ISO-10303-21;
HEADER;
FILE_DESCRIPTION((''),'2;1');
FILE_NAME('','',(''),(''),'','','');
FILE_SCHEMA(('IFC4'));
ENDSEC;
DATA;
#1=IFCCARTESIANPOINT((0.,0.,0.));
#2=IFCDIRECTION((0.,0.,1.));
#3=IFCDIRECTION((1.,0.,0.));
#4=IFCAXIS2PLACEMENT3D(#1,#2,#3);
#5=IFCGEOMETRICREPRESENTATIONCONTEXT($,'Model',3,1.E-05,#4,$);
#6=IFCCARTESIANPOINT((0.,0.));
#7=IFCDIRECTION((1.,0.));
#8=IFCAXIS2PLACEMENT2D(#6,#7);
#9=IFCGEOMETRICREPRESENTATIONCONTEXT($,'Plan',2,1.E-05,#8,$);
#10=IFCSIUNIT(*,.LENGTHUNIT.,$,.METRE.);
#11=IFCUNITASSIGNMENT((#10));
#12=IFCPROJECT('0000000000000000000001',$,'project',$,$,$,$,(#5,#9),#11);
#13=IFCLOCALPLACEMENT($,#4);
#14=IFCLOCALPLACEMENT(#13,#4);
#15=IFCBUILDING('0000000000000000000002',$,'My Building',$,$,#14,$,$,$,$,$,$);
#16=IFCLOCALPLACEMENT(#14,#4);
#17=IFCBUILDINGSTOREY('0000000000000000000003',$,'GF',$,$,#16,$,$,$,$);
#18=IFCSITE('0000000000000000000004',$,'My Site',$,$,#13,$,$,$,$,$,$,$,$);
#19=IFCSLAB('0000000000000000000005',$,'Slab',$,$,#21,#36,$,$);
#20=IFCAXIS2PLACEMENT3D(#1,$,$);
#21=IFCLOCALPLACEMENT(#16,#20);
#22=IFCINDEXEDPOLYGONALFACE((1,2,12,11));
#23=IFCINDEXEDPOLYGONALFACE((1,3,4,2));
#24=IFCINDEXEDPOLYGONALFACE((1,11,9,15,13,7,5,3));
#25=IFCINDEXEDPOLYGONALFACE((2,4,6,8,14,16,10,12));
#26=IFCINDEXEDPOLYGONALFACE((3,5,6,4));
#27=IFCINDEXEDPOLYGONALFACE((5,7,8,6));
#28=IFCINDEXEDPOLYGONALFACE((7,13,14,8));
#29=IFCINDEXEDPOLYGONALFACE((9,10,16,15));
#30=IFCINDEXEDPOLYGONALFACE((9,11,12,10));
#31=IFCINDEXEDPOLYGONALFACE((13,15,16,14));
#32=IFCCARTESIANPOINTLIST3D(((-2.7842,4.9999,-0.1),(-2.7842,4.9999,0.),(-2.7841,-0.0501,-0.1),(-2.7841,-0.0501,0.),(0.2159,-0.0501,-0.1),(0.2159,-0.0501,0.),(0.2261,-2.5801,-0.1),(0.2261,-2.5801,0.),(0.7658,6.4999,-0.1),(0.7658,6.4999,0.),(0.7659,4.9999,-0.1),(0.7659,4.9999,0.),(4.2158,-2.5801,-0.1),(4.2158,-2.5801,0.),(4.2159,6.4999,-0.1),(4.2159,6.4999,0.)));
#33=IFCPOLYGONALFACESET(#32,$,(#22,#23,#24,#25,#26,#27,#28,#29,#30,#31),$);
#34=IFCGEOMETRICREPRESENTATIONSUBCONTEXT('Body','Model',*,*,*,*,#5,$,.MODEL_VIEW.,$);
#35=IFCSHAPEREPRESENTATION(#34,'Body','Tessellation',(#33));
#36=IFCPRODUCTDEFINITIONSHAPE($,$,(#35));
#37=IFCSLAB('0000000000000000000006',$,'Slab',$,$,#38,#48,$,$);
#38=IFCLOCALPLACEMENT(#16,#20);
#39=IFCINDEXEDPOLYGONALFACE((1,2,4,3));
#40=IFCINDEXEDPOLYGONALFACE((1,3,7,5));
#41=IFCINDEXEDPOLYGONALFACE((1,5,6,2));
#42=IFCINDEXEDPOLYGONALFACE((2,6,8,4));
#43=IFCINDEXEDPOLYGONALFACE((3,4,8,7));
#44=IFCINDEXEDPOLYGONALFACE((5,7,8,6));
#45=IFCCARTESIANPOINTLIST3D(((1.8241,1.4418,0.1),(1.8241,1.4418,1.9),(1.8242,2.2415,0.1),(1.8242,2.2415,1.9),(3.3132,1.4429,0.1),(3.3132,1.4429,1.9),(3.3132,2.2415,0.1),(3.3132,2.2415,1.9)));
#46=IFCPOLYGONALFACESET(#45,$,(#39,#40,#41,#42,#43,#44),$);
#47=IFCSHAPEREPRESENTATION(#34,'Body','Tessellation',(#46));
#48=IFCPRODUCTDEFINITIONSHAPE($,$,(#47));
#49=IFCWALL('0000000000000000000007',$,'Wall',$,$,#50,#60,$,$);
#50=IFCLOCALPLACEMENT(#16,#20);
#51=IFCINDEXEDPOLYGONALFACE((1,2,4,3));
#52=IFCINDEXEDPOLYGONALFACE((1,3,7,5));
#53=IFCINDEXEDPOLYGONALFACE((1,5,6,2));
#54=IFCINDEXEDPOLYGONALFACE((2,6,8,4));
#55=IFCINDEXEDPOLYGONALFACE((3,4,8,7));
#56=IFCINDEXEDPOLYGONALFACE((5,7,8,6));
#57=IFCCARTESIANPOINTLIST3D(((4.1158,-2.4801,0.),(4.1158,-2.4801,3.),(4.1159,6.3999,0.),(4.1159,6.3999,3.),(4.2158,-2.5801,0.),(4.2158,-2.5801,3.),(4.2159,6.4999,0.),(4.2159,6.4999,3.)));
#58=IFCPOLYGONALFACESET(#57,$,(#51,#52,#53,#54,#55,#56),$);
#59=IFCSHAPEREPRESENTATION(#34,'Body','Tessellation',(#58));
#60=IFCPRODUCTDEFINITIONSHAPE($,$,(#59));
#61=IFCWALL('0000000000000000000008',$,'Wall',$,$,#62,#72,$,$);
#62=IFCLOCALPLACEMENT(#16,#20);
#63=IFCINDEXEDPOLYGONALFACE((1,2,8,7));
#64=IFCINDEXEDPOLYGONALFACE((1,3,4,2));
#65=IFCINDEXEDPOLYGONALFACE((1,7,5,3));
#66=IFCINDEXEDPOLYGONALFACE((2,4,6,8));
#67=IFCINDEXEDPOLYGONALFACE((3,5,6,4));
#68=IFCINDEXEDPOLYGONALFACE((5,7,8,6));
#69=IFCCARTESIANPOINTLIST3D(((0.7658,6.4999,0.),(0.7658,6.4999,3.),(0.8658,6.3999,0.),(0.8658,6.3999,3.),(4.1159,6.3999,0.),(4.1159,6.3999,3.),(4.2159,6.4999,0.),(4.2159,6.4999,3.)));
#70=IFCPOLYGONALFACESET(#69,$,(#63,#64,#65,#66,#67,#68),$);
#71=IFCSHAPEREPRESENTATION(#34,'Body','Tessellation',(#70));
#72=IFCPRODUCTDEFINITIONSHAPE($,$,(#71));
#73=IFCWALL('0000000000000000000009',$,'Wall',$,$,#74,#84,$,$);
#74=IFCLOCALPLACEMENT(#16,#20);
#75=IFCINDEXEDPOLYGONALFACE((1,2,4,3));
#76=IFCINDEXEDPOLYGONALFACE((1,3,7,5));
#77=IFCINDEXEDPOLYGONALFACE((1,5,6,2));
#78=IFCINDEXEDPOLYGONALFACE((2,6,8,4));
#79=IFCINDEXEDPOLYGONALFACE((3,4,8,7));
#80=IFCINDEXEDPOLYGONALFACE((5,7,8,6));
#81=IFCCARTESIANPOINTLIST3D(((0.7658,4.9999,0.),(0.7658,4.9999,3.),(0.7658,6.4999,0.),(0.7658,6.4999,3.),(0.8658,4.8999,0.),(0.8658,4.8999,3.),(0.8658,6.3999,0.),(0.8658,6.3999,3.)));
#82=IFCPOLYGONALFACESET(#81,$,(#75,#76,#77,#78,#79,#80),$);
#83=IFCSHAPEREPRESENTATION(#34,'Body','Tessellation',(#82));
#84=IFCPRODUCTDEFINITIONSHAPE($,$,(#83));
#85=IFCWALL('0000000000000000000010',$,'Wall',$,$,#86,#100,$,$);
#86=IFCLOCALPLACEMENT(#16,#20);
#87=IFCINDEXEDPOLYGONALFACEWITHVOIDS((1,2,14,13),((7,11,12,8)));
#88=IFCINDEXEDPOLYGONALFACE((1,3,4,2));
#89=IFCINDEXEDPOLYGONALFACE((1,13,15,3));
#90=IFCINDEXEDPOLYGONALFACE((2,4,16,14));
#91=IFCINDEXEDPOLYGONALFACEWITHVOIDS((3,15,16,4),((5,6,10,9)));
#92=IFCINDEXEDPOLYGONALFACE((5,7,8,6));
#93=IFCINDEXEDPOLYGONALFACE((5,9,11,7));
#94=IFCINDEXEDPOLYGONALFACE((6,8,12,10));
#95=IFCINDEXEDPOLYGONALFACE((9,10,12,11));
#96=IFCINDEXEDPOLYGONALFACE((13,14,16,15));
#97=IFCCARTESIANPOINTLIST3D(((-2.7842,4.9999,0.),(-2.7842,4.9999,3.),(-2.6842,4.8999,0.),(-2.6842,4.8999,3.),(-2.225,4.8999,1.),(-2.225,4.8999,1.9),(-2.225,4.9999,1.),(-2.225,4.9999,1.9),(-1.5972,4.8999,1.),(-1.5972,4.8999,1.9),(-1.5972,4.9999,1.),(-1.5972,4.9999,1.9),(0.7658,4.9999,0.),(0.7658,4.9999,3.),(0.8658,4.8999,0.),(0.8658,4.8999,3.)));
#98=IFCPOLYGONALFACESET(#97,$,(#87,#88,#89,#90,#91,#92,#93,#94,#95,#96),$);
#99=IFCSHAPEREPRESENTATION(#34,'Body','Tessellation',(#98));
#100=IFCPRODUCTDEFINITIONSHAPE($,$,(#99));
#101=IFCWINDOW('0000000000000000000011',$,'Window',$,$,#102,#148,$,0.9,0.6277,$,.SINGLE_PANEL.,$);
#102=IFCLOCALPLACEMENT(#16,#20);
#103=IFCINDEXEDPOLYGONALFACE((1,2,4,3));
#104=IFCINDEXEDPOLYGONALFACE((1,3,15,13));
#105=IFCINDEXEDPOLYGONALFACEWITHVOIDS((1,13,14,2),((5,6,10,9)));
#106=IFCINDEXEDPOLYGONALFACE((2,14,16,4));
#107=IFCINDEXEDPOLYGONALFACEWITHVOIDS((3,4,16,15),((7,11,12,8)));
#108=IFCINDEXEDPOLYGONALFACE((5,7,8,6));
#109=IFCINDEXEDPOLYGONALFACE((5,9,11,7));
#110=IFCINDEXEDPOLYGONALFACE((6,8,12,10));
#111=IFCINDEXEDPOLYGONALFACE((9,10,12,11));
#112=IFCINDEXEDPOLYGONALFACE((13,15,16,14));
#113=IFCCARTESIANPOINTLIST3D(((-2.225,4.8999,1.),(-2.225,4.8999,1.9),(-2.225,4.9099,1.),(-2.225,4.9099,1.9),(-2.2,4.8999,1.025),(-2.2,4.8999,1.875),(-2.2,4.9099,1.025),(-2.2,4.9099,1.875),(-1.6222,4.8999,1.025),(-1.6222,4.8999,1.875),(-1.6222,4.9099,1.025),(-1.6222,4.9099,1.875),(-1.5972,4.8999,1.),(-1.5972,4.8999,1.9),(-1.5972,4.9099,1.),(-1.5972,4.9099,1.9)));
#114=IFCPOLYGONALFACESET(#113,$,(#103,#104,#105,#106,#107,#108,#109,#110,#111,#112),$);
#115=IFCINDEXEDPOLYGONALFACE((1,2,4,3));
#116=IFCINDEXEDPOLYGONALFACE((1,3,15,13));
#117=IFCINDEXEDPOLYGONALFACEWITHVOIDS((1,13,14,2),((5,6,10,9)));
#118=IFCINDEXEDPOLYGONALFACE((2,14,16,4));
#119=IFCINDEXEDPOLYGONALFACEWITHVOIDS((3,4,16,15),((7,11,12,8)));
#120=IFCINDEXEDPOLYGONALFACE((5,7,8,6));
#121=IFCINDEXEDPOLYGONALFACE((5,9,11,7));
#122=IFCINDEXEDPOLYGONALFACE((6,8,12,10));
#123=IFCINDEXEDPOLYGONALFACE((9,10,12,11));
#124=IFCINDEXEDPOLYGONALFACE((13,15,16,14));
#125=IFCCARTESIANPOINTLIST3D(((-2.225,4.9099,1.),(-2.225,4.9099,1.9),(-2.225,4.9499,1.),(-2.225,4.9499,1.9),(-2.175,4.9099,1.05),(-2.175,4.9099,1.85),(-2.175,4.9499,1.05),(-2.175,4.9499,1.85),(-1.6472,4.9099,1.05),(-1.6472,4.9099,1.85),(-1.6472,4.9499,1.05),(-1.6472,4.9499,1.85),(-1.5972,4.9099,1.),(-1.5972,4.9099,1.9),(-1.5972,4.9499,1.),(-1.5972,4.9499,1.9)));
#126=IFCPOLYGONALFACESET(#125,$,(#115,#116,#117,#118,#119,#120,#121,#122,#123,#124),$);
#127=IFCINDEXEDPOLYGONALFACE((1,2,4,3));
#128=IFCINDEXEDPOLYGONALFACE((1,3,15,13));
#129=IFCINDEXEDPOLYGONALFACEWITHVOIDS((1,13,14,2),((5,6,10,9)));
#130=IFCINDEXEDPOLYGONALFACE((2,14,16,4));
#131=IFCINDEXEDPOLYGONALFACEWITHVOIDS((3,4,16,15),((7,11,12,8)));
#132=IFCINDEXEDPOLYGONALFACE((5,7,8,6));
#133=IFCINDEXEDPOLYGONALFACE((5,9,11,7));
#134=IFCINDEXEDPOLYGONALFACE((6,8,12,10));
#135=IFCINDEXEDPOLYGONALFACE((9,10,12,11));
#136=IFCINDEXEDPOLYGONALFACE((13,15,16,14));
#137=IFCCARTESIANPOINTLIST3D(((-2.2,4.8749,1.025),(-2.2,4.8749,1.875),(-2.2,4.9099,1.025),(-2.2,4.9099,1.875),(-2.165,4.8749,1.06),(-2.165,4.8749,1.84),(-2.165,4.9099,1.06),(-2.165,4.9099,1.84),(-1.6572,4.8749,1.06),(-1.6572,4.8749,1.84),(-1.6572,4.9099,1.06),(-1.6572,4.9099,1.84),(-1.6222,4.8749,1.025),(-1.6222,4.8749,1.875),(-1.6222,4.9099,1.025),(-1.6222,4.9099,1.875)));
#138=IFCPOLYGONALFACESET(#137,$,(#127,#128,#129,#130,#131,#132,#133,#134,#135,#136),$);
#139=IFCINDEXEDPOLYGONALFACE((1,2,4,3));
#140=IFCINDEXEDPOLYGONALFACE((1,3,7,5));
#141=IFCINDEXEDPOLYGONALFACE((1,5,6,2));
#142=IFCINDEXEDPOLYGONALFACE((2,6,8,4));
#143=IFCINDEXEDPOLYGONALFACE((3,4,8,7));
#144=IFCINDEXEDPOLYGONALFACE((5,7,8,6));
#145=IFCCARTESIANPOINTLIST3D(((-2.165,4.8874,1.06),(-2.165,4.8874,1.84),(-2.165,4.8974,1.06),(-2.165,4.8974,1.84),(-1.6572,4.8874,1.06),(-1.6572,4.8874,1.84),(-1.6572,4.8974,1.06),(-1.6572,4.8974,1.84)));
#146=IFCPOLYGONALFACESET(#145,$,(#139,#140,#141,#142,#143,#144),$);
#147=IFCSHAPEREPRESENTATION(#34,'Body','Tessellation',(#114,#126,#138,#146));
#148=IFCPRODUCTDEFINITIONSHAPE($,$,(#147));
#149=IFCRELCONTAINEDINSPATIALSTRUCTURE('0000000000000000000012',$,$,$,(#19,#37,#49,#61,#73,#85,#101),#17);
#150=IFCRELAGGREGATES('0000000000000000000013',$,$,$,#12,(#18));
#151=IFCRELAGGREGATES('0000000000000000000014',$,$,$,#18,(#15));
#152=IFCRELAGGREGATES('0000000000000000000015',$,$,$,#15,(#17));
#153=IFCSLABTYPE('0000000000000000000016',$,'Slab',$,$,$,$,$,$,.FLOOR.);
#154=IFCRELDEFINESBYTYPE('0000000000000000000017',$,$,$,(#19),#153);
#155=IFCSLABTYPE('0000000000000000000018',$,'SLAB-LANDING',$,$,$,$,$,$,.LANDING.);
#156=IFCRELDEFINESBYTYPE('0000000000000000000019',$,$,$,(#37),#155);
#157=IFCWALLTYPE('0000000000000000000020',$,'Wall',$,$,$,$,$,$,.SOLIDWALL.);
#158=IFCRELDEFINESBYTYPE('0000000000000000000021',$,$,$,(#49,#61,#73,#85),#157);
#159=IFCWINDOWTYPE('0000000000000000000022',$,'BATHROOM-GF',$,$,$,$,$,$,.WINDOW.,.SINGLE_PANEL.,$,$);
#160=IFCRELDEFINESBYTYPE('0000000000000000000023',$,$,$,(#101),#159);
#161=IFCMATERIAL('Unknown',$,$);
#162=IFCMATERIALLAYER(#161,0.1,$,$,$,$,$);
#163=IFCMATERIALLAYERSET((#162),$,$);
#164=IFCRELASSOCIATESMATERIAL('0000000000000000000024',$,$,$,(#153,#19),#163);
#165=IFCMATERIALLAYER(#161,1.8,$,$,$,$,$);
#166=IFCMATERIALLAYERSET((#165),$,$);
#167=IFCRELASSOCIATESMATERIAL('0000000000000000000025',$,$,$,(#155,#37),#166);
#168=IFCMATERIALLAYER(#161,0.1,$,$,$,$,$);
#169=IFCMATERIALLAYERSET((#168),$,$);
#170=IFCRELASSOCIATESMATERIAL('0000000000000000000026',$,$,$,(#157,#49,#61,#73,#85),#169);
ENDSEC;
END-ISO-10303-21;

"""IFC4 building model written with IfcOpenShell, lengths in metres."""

from ifc_helpers import new_model, entity, si_unit, frame, origin_with_axes, origin_2d_with_axis, place, context, subcontext, project, spatial, line, indexed_curve, outline, extrude, shape, source, transform, mapped, material, layer, layer_set, layer_usage, type_object, type_shapes, element, fill, save


model = new_model("IFC4")

# Units and contexts
model_context = context("Model", 3, precision=1e-05, world=origin_with_axes())
plan_context = context("Plan", 2, precision=1e-05, world=origin_2d_with_axis())
body_context_1 = subcontext(model_context, "Body", "Model", "MODEL_VIEW")
body_context_2 = subcontext(plan_context, "Body", "Plan", "PLAN_VIEW")
ifc_project = project(units=[si_unit("LENGTHUNIT", "METRE")], contexts=[model_context, plan_context])

# Site, building, storey
site_placement = place(None, origin_with_axes())
site = spatial("IfcSite", under=ifc_project, at=site_placement, Name="My Site")
building_placement = place(site_placement, origin_with_axes())
building = spatial("IfcBuilding", under=site, at=building_placement, Name="My Building")
storey_placement = place(building_placement, origin_with_axes())
storey = spatial("IfcBuildingStorey", under=building, at=storey_placement, Name="GF")

# Slabs
ifc_material_1 = material(Name="Unknown")
ifc_layer_1 = layer(ifc_material_1, 0.1)
ifc_layer_set_1 = layer_set([ifc_layer_1])
ifc_layer_usage_1 = layer_usage(ifc_layer_set_1, "AXIS3", "POSITIVE", -0.1)
slab_type_1 = type_object("IfcSlabType", Name="Slab", PredefinedType="FLOOR", material=ifc_layer_set_1)
slab_1_placement = place(storey_placement, frame((0.2261, -2.5801, 0.0), z_axis=(0.0, 0.0, 1.0), x_axis=(1.0, 0.0, 0.0)))
element("IfcSlab", 1, at=slab_1_placement, inside=storey, type_object=slab_type_1, material=ifc_layer_usage_1, Name="Slab", context=body_context_1, shape_type="SweptSolid", body=[
    extrude(outline(indexed_curve([(0.0, 0.0), (3.9897, 0.0), (3.9897, 9.08), (0.5397, 9.08), (0.5397, 7.58), (-3.0103, 7.58), (-3.0103, 2.53), (-0.0103, 2.53), (0.0, 0.0)])), frame((0.0, 0.0, -0.1), z_axis=(0.0, 0.0, 1.0), x_axis=(1.0, 0.0, 0.0)), (0.0, 0.0, 1.0), 0.1),
])
ifc_layer_2 = layer(ifc_material_1, 1.8)
ifc_layer_set_2 = layer_set([ifc_layer_2])
slab_type_2 = type_object("IfcSlabType", Name="SLAB-LANDING", PredefinedType="LANDING", material=ifc_layer_set_2)
ifc_layer_usage_2 = layer_usage(ifc_layer_set_2, "AXIS3", "POSITIVE", -1.8)
slab_2_placement = place(storey_placement, frame((1.8241, 1.4418, 1.9), z_axis=(0.0, 0.0, 1.0), x_axis=(1.0, 0.0, 0.0)))
element("IfcSlab", 2, at=slab_2_placement, inside=storey, type_object=slab_type_2, material=ifc_layer_usage_2, Name="Slab", context=body_context_1, shape_type="SweptSolid", body=[
    extrude(outline(indexed_curve([(0.0, 0.0), (1.489, 0.0011), (1.489, 0.7997), (0.0, 0.7997), (0.0, 0.0)])), frame((0.0, 0.0, -1.8), z_axis=(0.0, 0.0, 1.0), x_axis=(1.0, 0.0, 0.0)), (0.0, 0.0, 1.0), 1.8),
])

# Shared definitions
ifc_layer_3 = layer(ifc_material_1, 0.1)
ifc_layer_set_3 = layer_set([ifc_layer_3])
wall_type = type_object("IfcWallType", Name="Wall", PredefinedType="SOLIDWALL", material=ifc_layer_set_3)

# Walls
ifc_layer_usage_3 = layer_usage(ifc_layer_set_3, "AXIS2", "POSITIVE", 0.0)
wall_1_placement = place(storey_placement, frame((4.2158, -2.5801, 0.0), z_axis=(0.0, 0.0, 1.0), x_axis=(0.0, 1.0, 0.0)))
element("IfcWall", 3, at=wall_1_placement, inside=storey, type_object=wall_type, material=ifc_layer_usage_3, Name="Wall", context=body_context_1, shape_type="SweptSolid", body=[
    extrude(outline(indexed_curve([(0.0, 0.0), (0.1, 0.1), (8.98, 0.1), (9.08, 0.0)], segments=[line(1, 2, 3, 4, 1)])), origin_with_axes(), (0.0, 0.0, 1.0), 3.0),
])
ifc_layer_usage_4 = layer_usage(ifc_layer_set_3, "AXIS2", "POSITIVE", 0.0)
wall_2_placement = place(storey_placement, frame((4.2159, 6.4999, 0.0), z_axis=(0.0, 0.0, 1.0), x_axis=(-1.0, 0.0, 0.0)))
element("IfcWall", 4, at=wall_2_placement, inside=storey, type_object=wall_type, material=ifc_layer_usage_4, Name="Wall", context=body_context_1, shape_type="SweptSolid", body=[
    extrude(outline(indexed_curve([(0.0, 0.0), (0.1, 0.1), (3.35, 0.1), (3.45, 0.0)], segments=[line(1, 2, 3, 4, 1)])), origin_with_axes(), (0.0, 0.0, 1.0), 3.0),
])
ifc_layer_usage_5 = layer_usage(ifc_layer_set_3, "AXIS2", "POSITIVE", 0.0)
wall_3_placement = place(storey_placement, frame((0.7658, 6.4999, 0.0), z_axis=(0.0, 0.0, 1.0), x_axis=(0.0, -1.0, 0.0)))
element("IfcWall", 5, at=wall_3_placement, inside=storey, type_object=wall_type, material=ifc_layer_usage_5, Name="Wall", context=body_context_1, shape_type="SweptSolid", body=[
    extrude(outline(indexed_curve([(0.0, 0.0), (0.1, 0.1), (1.6, 0.1), (1.5, 0.0)], segments=[line(1, 2, 3, 4, 1)])), origin_with_axes(), (0.0, 0.0, 1.0), 3.0),
])

# Wall, opening, window
ifc_layer_usage_6 = layer_usage(ifc_layer_set_3, "AXIS2", "POSITIVE", 0.0)
wall_4_placement = place(storey_placement, frame((0.7658, 4.9999, 0.0), z_axis=(0.0, 0.0, 1.0), x_axis=(-1.0, 0.0, 0.0)))
wall_4 = element("IfcWall", 6, at=wall_4_placement, inside=storey, type_object=wall_type, material=ifc_layer_usage_6, Name="Wall", context=body_context_1, shape_type="SweptSolid", body=[
    extrude(outline(indexed_curve([(0.0, 0.0), (-0.1, 0.1), (3.45, 0.1), (3.55, 0.0)], segments=[line(1, 2, 3, 4, 1)])), origin_with_axes(), (0.0, 0.0, 1.0), 3.0),
])
shared_shape_1 = source(origin_with_axes(), body_context_1, "Body", "SweptSolid", [
    extrude(outline(indexed_curve([(0.0, 0.0), (0.6277, 0.0), (0.6277, 0.9), (0.0, 0.9)], segments=[line(1, 2, 3, 4, 1)])), frame((0.0, -0.6, 0.0), z_axis=(0.0, -1.0, 0.0), x_axis=(1.0, 0.0, 0.0)), (0.0, 0.0, -1.0), 1.2),
])
opening_1_placement = place(wall_4_placement, frame((2.3631, 0.0, 1.0), z_axis=(0.0, 0.0, 1.0), x_axis=(1.0, 0.0, 0.0)))
opening_1 = element("IfcOpeningElement", 7, at=opening_1_placement, cuts=wall_4, PredefinedType="OPENING", context=body_context_1, shape_type="MappedRepresentation", body=[
    mapped(shared_shape_1, transform((0.0, 0.0, 0.0), x_axis=(1.0, 0.0, 0.0), y_axis=(0.0, 1.0, 0.0), z_axis=(0.0, 0.0, 1.0), scale=1.0)),
])
window_type_1 = type_object("IfcWindowType", Name="BATHROOM-GF", PartitioningType="SINGLE_PANEL", PredefinedType="WINDOW")
shared_shape_2 = source(origin_with_axes(), body_context_1, "Body", "SweptSolid", [
    extrude(outline(indexed_curve([(0.0, 0.0), (0.6277, 0.0), (0.6277, 0.9), (0.0, 0.9)], segments=[line(1, 2, 3, 4, 1)]), holes=[indexed_curve([(0.025, 0.025), (0.6027, 0.025), (0.6027, 0.875), (0.025, 0.875)], segments=[line(1, 2, 3, 4, 1)])]), frame((0.0, 0.09, 0.0), z_axis=(0.0, -1.0, 0.0), x_axis=(1.0, 0.0, 0.0)), (0.0, 0.0, -1.0), 0.01),
    extrude(outline(indexed_curve([(0.0, 0.0), (0.6277, 0.0), (0.6277, 0.9), (0.0, 0.9)], segments=[line(1, 2, 3, 4, 1)]), holes=[indexed_curve([(0.05, 0.05), (0.5777, 0.05), (0.5777, 0.85), (0.05, 0.85)], segments=[line(1, 2, 3, 4, 1)])]), frame((0.0, 0.05, 0.0), z_axis=(0.0, -1.0, 0.0), x_axis=(1.0, 0.0, 0.0)), (0.0, 0.0, -1.0), 0.04),
    extrude(outline(indexed_curve([(0.0, 0.0), (0.5777, 0.0), (0.5777, 0.85), (0.0, 0.85)], segments=[line(1, 2, 3, 4, 1)]), holes=[indexed_curve([(0.035, 0.035), (0.5427, 0.035), (0.5427, 0.815), (0.035, 0.815)], segments=[line(1, 2, 3, 4, 1)])]), frame((0.025, 0.09, 0.025), z_axis=(0.0, -1.0, 0.0), x_axis=(1.0, 0.0, 0.0)), (0.0, 0.0, -1.0), 0.035),
    extrude(outline(indexed_curve([(0.035, 0.035), (0.5427, 0.035), (0.5427, 0.815), (0.035, 0.815)], segments=[line(1, 2, 3, 4, 1)])), frame((0.025, 0.1025, 0.025), z_axis=(0.0, -1.0, 0.0), x_axis=(1.0, 0.0, 0.0)), (0.0, 0.0, -1.0), 0.01),
])
shared_shape_3 = source(origin_with_axes(), body_context_2, "Body", "Curve2D", [
    entity("IfcIndexedPolyCurve", entity("IfcCartesianPointList2D", [[0.05, 0.05], [0.5777, 0.05]])),
    entity("IfcIndexedPolyCurve", entity("IfcCartesianPointList2D", [[0.0, 0.1], [0.025, 0.1], [0.025, 0.09], [0.05, 0.09], [0.05, 0.05], [0.0, 0.05]]), [entity("IfcLineIndex", [1, 2, 3, 4, 5, 6, 1])]),
    entity("IfcIndexedPolyCurve", entity("IfcCartesianPointList2D", [[0.6277, 0.1], [0.6027, 0.1], [0.6027, 0.09], [0.5777, 0.09], [0.5777, 0.05], [0.6277, 0.05]]), [entity("IfcLineIndex", [1, 2, 3, 4, 5, 6, 1])]),
    entity("IfcIndexedPolyCurve", entity("IfcCartesianPointList2D", [[0.025, 0.09], [0.06, 0.09], [0.06, 0.125], [0.025, 0.125]]), [entity("IfcLineIndex", [1, 2, 3, 4, 1])]),
    entity("IfcIndexedPolyCurve", entity("IfcCartesianPointList2D", [[0.6027, 0.09], [0.5677, 0.09], [0.5677, 0.125], [0.6027, 0.125]]), [entity("IfcLineIndex", [1, 2, 3, 4, 1])]),
    entity("IfcIndexedPolyCurve", entity("IfcCartesianPointList2D", [[0.06, 0.09], [0.5677, 0.09]])),
    entity("IfcIndexedPolyCurve", entity("IfcCartesianPointList2D", [[0.06, 0.125], [0.5677, 0.125]])),
    entity("IfcIndexedPolyCurve", entity("IfcCartesianPointList2D", [[0.06, 0.1075], [0.5677, 0.1075]])),
])
type_shapes(window_type_1, [shared_shape_2, shared_shape_3])
window_1_placement = place(opening_1_placement, frame((0.0, 0.0, 0.0), z_axis=(0.0, 0.0, 1.0), x_axis=(1.0, 0.0, 0.0)))
window_1 = element("IfcWindow", 8, at=window_1_placement, inside=storey, type_object=window_type_1, Name="Window", OverallHeight=0.9, OverallWidth=0.6277, PartitioningType="SINGLE_PANEL", shapes=[
    shape(body_context_1, "Body", "MappedRepresentation", [mapped(shared_shape_2, transform((0.0, 0.0, 0.0), x_axis=(1.0, 0.0, 0.0), y_axis=(0.0, 1.0, 0.0), z_axis=(0.0, 0.0, 1.0), scale=1.0))]),
    shape(body_context_2, "Body", "MappedRepresentation", [mapped(shared_shape_3, transform((0.0, 0.0, 0.0), x_axis=(1.0, 0.0, 0.0), y_axis=(0.0, 1.0, 0.0), z_axis=(0.0, 0.0, 1.0), scale=1.0))]),
])
fill(opening_1, window_1)

save(model, "model.ifc")
